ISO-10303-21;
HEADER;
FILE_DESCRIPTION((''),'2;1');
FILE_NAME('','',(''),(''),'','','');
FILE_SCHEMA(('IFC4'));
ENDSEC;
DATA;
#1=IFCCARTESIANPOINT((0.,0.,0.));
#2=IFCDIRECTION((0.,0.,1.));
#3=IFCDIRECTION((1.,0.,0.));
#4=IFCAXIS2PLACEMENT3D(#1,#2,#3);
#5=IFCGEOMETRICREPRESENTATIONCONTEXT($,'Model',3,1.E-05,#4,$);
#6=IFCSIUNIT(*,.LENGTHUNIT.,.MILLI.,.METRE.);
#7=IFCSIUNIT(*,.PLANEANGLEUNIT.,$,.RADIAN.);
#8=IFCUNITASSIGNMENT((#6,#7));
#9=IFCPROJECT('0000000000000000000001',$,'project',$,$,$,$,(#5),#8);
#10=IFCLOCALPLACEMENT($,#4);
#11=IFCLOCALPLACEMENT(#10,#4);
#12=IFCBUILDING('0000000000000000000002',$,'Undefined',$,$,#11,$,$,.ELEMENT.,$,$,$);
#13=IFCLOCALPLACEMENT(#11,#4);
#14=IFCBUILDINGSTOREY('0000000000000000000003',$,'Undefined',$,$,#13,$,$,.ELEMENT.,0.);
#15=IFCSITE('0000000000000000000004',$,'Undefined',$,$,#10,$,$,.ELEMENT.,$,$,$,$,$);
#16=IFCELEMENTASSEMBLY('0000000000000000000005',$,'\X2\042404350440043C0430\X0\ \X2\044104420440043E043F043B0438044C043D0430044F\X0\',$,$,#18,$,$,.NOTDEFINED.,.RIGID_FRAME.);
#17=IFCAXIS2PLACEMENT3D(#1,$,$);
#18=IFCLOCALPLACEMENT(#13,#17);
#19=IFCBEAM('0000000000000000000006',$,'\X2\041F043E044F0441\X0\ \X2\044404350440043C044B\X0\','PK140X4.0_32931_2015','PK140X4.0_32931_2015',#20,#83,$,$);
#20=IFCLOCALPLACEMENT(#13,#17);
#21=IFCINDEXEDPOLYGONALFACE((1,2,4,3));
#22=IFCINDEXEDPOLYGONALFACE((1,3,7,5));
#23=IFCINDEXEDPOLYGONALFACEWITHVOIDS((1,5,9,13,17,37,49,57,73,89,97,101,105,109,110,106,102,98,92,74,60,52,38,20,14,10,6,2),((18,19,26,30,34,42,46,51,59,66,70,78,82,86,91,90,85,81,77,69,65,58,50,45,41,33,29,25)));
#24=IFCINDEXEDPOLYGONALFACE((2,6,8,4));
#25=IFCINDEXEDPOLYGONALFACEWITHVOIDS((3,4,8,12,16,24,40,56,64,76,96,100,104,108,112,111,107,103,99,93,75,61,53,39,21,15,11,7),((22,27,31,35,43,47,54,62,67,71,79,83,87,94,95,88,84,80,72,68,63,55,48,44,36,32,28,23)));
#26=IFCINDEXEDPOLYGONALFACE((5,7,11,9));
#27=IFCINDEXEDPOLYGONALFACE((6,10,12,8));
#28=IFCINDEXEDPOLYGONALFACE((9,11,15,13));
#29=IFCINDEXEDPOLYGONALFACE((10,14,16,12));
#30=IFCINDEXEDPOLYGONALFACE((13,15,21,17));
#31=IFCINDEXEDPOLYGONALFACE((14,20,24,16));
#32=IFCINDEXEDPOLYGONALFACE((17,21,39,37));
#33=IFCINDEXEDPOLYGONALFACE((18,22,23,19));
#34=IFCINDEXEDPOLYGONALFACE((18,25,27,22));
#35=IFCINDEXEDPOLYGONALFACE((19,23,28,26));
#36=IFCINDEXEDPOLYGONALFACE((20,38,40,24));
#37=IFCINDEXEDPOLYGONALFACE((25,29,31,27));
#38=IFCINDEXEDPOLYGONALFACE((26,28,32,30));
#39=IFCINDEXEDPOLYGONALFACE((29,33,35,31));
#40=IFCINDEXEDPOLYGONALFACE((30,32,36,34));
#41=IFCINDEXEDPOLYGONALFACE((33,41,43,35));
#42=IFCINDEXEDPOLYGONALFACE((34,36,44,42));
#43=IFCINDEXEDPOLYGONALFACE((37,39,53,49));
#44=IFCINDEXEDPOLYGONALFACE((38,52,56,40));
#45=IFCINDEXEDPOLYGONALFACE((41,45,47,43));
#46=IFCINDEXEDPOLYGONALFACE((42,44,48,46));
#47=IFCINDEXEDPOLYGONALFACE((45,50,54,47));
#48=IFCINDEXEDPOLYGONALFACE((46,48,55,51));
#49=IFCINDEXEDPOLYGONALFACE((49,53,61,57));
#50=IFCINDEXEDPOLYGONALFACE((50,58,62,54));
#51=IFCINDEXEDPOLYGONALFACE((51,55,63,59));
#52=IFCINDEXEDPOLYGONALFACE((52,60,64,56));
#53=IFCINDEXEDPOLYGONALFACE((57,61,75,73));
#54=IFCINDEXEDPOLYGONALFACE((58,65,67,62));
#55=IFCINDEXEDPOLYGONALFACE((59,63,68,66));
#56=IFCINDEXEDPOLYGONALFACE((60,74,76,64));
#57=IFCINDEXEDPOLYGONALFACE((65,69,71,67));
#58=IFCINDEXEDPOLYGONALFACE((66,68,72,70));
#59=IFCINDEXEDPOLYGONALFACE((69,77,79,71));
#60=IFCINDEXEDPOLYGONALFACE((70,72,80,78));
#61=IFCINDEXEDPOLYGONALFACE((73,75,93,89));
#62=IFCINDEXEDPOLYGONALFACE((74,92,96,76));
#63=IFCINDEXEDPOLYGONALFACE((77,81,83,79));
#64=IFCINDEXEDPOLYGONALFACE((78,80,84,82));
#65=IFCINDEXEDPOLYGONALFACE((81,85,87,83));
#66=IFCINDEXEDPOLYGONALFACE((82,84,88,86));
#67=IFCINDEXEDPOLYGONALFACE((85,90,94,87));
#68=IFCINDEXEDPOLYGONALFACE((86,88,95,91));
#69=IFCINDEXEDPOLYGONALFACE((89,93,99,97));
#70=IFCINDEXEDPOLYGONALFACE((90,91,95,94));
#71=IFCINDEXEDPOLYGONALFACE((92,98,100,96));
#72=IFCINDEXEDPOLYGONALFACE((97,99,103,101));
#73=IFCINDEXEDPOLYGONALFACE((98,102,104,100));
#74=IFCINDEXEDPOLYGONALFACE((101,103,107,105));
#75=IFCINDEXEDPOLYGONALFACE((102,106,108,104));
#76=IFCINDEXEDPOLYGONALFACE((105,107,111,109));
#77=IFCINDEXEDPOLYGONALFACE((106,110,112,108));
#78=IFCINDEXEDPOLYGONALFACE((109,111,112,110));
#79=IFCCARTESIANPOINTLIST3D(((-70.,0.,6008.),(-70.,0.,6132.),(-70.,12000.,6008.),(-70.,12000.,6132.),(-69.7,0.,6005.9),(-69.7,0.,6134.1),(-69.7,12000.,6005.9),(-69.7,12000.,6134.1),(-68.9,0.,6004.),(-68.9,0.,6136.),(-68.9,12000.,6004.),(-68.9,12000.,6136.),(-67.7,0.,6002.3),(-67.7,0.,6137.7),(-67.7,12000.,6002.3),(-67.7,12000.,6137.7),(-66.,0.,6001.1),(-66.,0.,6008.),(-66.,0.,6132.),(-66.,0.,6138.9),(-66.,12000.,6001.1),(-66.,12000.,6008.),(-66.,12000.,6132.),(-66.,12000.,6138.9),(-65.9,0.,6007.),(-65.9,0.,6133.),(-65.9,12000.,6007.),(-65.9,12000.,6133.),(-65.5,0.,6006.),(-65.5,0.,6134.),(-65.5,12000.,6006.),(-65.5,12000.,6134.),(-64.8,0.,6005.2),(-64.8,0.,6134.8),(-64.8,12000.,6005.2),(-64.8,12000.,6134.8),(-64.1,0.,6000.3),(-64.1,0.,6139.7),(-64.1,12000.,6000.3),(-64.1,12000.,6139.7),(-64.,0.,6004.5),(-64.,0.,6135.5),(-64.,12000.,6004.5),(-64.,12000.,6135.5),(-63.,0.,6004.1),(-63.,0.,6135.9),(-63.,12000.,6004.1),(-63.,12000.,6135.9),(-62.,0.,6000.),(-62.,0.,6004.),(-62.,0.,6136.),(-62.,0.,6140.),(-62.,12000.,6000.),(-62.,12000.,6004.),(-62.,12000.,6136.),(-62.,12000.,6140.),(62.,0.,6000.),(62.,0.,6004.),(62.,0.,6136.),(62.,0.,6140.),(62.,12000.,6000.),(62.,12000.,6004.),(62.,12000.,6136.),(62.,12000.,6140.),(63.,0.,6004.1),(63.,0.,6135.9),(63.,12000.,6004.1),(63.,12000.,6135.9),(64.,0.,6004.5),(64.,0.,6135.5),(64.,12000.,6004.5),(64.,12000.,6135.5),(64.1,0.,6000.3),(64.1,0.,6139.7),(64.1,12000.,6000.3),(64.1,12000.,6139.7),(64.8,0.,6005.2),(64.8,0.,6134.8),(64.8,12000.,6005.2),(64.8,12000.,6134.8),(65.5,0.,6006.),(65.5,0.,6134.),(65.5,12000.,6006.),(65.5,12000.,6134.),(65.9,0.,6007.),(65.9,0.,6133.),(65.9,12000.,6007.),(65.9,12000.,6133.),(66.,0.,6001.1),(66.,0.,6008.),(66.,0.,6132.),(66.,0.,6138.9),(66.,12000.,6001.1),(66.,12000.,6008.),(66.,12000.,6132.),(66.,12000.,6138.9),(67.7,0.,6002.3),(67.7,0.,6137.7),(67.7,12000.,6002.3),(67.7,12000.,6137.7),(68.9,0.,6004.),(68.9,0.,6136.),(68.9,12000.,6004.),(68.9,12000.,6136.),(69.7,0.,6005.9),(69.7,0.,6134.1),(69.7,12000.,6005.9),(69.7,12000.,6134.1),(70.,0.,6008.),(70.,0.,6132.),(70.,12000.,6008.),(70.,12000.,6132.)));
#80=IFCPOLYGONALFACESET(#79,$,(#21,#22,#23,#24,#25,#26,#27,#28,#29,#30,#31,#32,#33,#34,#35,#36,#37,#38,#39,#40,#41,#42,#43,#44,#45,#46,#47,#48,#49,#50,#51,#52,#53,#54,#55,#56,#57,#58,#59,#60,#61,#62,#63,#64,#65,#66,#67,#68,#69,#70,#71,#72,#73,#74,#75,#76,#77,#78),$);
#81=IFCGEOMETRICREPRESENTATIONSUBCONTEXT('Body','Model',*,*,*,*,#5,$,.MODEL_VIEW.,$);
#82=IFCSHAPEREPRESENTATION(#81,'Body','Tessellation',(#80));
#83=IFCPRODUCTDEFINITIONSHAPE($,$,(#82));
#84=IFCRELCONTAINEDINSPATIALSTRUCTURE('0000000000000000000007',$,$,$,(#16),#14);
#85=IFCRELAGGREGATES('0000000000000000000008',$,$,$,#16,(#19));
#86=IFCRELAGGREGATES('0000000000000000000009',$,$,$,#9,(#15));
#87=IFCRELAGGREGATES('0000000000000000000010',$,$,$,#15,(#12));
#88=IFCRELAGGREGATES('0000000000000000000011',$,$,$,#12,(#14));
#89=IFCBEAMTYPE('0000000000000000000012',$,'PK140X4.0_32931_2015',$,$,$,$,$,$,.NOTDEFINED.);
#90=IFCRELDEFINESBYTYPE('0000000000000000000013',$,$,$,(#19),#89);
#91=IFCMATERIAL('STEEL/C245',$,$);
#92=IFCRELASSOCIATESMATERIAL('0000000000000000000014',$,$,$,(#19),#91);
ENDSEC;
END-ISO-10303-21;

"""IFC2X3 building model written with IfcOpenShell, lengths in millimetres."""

from ifc_helpers import new_model, si_unit, frame, origin_with_axes, origin_2d_with_axis, place, context, subcontext, project, spatial, hollow_rectangle, extrude, material, type_object, element, aggregate, save


model = new_model("IFC2X3")

# Units and contexts
model_context = context("Model", 3, precision=1e-05, world=origin_with_axes())
body_context = subcontext(model_context, "Body", "Model", "MODEL_VIEW")
ifc_project = project(units=[si_unit("LENGTHUNIT", "METRE", prefix="MILLI"), si_unit("PLANEANGLEUNIT", "RADIAN")], contexts=[model_context])

# Site, building, storey
site_placement = place(None, origin_with_axes())
site = spatial("IfcSite", under=ifc_project, at=site_placement, Name="Undefined", CompositionType="ELEMENT")
building_placement = place(site_placement, origin_with_axes())
building = spatial("IfcBuilding", under=site, at=building_placement, Name="Undefined", CompositionType="ELEMENT")
storey_placement = place(building_placement, origin_with_axes())
storey = spatial("IfcBuildingStorey", under=building, at=storey_placement, Name="Undefined", CompositionType="ELEMENT", Elevation=0.0)

# Shared definitions
ifc_material = material(Name="STEEL/C245")

# Element assembly, beam
assembly_1_placement = place(storey_placement, origin_with_axes())
assembly_1 = element("IfcElementAssembly", 1, at=assembly_1_placement, inside=storey, Name="Ферма строплиьная", AssemblyPlace="NOTDEFINED", PredefinedType="RIGID_FRAME")
beam_type_1 = type_object("IfcBeamType", Name="PK140X4.0_32931_2015", PredefinedType="NOTDEFINED")
beam_1_placement = place(assembly_1_placement, frame((0.0, 0.0, 6070.0), z_axis=(0.0, 0.0, 1.0), x_axis=(0.0, 1.0, 0.0)))
beam_1 = element("IfcBeam", 2, at=beam_1_placement, type_object=beam_type_1, material=ifc_material, Name="Пояс фермы", Description="PK140X4.0_32931_2015", ObjectType="PK140X4.0_32931_2015", context=body_context, shape_type="SweptSolid", body=[
    extrude(hollow_rectangle(XDim=140.0, YDim=140.0, WallThickness=4.0, InnerFilletRadius=4.0, OuterFilletRadius=8.0, at=origin_2d_with_axis()), frame((12000.0, 0.0, 0.0), z_axis=(-1.0, 0.0, 0.0), x_axis=(0.0, -1.0, 0.0)), (0.0, 0.0, 1.0), 12000.0),
])
aggregate(assembly_1, [beam_1])

save(model, "model.ifc")
